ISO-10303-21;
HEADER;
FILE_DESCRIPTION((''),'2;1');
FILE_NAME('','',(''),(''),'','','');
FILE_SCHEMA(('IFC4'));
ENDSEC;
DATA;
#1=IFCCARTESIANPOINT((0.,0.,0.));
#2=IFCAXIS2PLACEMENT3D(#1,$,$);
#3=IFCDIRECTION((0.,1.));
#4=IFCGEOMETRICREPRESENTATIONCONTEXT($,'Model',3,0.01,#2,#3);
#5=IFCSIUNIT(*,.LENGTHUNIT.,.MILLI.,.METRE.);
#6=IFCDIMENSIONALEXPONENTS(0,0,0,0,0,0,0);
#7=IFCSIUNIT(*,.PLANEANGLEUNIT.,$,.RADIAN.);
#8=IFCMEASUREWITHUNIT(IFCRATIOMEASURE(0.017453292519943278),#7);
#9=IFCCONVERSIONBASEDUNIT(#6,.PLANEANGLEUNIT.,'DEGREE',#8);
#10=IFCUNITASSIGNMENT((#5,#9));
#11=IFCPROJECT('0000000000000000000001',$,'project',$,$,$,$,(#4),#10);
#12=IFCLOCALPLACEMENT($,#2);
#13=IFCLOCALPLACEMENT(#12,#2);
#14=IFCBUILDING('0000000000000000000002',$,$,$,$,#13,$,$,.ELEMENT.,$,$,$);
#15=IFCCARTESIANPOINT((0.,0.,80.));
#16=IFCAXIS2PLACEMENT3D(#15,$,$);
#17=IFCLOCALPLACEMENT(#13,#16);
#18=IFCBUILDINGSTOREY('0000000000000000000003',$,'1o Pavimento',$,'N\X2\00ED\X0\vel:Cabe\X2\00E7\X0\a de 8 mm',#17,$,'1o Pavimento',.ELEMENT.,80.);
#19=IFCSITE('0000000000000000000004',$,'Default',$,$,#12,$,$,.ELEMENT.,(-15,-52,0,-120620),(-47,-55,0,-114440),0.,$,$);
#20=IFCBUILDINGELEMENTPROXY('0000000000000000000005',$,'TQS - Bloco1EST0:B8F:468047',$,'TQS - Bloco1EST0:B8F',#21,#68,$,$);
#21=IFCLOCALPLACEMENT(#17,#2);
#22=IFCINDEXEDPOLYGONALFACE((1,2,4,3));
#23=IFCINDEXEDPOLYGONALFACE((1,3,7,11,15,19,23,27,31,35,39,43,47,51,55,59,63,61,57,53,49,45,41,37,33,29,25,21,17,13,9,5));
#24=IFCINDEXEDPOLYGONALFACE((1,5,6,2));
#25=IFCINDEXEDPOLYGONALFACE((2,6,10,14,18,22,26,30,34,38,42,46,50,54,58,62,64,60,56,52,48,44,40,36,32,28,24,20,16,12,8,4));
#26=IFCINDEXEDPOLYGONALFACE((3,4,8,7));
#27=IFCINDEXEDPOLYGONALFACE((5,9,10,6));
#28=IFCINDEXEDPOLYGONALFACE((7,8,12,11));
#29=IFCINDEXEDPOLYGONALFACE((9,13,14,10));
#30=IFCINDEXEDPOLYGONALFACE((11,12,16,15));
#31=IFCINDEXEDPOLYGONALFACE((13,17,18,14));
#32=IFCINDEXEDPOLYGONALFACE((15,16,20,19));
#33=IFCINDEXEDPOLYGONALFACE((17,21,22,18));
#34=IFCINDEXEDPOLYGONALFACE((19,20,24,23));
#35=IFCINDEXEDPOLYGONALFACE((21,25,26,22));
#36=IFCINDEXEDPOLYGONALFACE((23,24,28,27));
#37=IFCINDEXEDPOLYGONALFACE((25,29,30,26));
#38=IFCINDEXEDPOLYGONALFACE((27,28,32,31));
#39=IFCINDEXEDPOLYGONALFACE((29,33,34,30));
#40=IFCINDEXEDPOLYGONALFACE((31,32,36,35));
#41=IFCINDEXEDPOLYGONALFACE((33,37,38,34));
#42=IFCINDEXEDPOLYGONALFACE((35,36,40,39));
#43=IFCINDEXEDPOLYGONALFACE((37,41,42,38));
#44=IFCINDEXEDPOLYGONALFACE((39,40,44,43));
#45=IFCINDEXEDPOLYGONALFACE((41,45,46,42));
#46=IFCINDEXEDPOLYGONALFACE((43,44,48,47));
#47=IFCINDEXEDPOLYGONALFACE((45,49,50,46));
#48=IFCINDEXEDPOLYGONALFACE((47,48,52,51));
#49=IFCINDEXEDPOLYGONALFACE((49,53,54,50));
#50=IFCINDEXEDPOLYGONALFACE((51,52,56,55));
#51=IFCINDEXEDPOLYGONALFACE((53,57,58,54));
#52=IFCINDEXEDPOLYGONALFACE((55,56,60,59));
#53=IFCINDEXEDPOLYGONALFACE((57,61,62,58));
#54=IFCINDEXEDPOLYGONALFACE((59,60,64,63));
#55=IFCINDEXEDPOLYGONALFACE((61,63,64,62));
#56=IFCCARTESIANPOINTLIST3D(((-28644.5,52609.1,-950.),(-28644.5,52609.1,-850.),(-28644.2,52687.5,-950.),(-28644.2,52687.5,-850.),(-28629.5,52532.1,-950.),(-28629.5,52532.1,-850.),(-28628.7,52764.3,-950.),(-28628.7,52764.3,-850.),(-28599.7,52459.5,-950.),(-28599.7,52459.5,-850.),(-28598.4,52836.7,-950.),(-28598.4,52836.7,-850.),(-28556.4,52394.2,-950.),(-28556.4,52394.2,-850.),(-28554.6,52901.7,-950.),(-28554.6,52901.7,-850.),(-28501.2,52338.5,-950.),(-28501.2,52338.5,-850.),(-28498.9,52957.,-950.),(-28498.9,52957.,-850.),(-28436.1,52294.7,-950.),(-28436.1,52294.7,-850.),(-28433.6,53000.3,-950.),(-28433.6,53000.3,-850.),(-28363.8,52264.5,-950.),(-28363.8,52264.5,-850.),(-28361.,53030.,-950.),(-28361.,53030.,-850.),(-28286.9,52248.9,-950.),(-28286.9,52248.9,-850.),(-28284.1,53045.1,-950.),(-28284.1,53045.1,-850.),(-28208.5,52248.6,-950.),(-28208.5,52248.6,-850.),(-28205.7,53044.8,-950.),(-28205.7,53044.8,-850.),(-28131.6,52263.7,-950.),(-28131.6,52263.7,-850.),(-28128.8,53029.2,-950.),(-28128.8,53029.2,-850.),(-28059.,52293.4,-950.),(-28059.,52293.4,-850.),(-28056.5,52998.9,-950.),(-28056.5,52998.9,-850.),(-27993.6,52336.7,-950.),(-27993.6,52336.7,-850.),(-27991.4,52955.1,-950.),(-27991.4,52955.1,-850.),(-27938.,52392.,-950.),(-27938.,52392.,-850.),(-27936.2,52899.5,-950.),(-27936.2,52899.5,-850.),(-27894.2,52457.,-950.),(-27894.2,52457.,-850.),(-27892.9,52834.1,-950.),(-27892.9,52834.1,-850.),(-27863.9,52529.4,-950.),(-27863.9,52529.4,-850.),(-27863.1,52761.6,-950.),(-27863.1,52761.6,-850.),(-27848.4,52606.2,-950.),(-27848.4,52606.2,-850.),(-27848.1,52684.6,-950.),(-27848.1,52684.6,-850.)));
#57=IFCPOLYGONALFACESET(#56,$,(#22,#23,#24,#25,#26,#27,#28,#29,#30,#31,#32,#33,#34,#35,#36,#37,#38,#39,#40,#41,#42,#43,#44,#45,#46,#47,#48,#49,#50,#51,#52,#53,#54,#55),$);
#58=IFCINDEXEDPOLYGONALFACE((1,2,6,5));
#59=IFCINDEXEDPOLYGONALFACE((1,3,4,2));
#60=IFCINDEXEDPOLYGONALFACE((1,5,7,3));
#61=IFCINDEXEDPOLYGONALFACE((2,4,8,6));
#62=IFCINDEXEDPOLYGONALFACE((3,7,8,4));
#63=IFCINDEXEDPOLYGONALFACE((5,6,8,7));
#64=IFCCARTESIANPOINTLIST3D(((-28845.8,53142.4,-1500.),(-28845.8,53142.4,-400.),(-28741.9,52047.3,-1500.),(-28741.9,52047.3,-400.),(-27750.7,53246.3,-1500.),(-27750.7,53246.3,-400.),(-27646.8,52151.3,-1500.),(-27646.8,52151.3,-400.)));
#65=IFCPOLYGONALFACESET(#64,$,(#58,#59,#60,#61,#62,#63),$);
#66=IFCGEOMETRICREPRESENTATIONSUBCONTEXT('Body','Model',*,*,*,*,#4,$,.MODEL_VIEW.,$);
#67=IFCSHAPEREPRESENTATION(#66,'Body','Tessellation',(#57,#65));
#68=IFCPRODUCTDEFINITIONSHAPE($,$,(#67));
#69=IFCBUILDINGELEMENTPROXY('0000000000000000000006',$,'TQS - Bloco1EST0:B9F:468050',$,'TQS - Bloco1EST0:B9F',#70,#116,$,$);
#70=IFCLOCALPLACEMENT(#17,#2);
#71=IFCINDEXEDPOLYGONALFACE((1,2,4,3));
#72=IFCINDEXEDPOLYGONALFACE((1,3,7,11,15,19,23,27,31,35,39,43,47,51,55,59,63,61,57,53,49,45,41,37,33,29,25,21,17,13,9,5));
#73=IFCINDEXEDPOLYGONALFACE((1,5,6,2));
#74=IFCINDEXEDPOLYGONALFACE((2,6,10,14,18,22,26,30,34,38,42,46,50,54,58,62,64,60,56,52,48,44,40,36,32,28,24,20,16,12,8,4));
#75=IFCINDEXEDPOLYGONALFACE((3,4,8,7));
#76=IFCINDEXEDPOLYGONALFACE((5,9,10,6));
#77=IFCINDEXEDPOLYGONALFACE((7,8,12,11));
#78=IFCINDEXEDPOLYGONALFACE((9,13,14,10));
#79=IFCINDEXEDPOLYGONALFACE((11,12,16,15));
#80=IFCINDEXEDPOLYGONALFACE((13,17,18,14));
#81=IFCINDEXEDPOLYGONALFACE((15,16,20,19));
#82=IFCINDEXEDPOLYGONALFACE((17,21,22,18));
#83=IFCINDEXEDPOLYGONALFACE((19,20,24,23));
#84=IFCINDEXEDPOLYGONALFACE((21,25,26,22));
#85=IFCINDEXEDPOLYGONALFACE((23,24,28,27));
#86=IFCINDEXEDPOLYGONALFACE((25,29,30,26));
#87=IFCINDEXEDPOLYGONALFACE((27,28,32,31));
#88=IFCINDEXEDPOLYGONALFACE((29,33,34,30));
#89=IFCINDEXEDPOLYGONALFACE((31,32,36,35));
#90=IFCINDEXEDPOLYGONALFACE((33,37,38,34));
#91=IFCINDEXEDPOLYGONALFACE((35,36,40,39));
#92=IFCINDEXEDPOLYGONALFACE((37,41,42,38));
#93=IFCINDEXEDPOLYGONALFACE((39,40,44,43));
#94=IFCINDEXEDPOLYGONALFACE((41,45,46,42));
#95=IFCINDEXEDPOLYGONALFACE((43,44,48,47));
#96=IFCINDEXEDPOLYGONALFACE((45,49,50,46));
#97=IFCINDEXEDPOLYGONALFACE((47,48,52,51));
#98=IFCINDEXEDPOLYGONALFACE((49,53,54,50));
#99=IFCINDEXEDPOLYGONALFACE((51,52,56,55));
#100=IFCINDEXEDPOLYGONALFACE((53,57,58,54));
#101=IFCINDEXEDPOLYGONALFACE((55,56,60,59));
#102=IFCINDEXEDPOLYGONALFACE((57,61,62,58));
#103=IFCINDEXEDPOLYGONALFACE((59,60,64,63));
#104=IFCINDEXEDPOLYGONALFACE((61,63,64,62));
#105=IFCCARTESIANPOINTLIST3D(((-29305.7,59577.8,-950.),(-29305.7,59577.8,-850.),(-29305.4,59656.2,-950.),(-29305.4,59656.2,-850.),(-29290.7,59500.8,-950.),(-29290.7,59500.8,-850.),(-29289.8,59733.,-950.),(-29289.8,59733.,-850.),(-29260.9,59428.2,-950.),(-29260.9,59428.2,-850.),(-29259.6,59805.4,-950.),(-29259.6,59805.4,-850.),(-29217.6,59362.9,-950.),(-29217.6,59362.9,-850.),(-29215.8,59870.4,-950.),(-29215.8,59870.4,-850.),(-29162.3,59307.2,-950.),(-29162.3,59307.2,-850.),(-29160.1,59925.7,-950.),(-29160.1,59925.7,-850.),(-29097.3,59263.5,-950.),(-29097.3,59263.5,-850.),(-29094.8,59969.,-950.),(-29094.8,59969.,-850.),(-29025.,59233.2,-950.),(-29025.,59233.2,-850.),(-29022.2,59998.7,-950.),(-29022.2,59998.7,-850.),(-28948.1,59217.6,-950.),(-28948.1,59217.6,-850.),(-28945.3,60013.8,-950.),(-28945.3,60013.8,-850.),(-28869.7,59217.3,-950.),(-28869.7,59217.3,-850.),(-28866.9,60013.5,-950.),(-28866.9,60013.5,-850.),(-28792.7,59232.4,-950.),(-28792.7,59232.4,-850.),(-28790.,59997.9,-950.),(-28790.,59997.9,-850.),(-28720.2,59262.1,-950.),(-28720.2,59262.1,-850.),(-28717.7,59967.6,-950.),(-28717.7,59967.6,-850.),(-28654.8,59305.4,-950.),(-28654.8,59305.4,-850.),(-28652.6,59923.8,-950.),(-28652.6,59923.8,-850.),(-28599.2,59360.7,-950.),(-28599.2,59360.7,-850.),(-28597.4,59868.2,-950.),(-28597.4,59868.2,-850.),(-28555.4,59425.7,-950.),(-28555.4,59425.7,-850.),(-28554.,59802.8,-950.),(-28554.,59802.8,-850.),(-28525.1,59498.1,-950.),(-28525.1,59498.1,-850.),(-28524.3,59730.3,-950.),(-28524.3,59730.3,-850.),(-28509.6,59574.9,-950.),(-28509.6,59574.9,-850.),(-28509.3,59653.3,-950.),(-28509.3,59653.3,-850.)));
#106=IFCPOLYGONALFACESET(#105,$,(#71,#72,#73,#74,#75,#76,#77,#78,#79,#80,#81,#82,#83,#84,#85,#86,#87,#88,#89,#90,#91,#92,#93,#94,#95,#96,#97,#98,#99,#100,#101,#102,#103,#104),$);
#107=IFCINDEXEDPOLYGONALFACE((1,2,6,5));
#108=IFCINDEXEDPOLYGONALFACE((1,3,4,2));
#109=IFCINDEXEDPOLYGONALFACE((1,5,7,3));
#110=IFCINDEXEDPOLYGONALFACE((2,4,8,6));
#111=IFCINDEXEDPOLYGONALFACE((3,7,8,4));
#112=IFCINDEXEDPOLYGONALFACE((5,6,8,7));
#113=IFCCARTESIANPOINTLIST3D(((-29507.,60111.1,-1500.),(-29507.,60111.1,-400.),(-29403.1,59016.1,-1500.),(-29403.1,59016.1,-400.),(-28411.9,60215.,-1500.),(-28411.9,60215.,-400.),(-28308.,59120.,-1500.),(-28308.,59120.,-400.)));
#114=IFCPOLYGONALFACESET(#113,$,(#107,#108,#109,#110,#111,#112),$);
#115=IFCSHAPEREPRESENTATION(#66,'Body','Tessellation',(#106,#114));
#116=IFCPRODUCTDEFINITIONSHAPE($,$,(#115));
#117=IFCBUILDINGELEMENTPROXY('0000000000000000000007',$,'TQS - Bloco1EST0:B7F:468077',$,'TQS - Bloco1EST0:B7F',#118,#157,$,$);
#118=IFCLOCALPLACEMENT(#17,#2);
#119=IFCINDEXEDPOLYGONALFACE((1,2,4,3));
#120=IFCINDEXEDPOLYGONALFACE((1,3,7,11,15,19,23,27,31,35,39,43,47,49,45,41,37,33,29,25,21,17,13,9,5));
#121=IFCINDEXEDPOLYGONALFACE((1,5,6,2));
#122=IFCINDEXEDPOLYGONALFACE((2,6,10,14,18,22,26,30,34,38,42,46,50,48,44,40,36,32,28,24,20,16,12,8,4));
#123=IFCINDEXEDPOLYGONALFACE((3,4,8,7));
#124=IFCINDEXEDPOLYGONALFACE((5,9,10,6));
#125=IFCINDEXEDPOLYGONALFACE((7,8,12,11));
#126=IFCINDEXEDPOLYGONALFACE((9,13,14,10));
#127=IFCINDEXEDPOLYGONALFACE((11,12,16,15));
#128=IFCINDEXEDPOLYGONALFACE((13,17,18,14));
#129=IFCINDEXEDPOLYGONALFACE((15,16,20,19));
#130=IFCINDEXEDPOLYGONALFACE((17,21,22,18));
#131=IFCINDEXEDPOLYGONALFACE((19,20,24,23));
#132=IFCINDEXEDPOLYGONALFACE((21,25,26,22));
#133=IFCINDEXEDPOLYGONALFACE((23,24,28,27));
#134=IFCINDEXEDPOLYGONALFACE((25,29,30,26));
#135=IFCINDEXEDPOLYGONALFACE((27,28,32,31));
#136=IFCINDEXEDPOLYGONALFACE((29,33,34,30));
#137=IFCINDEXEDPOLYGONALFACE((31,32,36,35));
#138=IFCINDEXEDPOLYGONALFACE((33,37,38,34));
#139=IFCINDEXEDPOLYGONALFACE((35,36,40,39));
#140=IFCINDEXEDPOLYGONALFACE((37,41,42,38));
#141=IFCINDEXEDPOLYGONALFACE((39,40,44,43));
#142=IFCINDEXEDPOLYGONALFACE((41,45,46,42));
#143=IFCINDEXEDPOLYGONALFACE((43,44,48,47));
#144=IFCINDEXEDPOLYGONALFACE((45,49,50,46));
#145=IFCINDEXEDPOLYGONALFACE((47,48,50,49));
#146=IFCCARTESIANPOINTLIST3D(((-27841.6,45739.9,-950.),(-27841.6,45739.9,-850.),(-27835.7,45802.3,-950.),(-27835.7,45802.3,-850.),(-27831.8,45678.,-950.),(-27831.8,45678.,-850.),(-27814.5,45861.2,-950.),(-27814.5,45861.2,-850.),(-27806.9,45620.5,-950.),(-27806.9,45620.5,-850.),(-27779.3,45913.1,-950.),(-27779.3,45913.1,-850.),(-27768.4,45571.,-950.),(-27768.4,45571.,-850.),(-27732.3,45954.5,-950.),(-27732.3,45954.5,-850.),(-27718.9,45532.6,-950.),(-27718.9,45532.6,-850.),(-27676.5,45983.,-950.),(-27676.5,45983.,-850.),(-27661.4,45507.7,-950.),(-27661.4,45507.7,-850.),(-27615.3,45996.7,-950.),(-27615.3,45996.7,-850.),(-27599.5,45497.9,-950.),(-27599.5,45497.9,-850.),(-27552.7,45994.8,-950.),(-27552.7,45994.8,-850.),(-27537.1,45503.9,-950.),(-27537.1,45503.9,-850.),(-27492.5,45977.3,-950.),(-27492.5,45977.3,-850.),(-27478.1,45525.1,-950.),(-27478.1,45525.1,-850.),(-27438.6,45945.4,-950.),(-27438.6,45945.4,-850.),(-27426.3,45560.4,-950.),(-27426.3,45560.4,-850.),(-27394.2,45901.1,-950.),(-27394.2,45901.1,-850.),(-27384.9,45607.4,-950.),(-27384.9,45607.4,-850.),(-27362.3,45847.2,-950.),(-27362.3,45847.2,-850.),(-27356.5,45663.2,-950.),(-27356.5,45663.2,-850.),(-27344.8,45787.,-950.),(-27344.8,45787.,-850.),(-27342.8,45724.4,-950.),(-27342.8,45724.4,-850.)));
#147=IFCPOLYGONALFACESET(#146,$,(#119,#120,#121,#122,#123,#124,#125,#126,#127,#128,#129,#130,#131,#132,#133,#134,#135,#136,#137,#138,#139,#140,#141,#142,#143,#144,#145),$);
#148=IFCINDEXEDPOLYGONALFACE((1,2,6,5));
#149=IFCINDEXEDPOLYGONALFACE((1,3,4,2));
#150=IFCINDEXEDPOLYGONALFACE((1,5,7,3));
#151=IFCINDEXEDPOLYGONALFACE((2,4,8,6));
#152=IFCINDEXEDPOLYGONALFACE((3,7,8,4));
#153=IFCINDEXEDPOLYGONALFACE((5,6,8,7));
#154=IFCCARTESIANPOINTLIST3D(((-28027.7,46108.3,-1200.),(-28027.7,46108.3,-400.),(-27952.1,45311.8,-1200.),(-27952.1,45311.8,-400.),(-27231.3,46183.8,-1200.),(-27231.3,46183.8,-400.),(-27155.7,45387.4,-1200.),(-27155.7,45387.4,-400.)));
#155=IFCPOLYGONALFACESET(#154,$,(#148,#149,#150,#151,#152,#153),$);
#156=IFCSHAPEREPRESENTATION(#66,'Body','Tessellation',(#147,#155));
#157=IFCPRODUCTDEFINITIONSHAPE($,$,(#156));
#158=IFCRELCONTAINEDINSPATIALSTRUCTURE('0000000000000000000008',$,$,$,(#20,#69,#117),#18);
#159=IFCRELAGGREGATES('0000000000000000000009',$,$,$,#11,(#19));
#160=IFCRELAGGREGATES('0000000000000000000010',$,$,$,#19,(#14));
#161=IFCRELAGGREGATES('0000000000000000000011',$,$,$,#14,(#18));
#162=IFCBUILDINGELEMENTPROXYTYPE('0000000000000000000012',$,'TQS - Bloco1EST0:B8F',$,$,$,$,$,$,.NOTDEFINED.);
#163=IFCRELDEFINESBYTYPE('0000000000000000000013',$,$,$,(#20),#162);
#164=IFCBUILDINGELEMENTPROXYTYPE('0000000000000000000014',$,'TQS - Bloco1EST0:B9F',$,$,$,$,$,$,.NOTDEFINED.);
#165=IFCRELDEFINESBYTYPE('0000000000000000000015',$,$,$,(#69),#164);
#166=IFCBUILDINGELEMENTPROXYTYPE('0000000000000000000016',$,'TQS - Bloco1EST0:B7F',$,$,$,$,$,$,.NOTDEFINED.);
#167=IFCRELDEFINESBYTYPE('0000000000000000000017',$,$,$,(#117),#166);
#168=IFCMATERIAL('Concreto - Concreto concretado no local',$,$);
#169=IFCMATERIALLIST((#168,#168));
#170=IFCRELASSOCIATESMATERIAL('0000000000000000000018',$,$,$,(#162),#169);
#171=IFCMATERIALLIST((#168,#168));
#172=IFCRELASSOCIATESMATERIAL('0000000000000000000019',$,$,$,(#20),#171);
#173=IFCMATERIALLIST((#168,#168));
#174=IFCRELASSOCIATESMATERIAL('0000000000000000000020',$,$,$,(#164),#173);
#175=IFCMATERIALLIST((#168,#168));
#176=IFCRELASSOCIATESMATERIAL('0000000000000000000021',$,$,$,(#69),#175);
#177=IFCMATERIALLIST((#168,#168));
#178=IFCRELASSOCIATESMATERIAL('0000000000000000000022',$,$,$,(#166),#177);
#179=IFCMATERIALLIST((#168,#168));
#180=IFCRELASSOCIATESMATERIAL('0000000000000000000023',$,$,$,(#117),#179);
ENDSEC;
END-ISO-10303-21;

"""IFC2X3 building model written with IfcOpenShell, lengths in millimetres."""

from ifc_helpers import new_model, entity, si_unit, converted_unit, direction, frame, frame_2d, origin, origin_2d_with_axis, place, context, subcontext, project, spatial, rectangle, circle, extrude, source, transform, mapped, material, material_list, type_object, type_shapes, element, save


model = new_model("IFC2X3")

# Units and contexts
model_context = context("Model", 3, precision=0.01, world=origin(), true_north=direction((0.0, 1.0)))
body_context = subcontext(model_context, "Body", "Model", "MODEL_VIEW")
ifc_project = project(units=[si_unit("LENGTHUNIT", "METRE", prefix="MILLI"), converted_unit("PLANEANGLEUNIT", "DEGREE", entity("IfcRatioMeasure", 0.017453292519943278), si_unit("PLANEANGLEUNIT", "RADIAN"), dimensions=[0, 0, 0, 0, 0, 0, 0])], contexts=[model_context])

# Site, building, storey
site_placement = place(None, origin())
site = spatial("IfcSite", under=ifc_project, at=site_placement, Name="Default", CompositionType="ELEMENT", RefLatitude=(-15, -52, 0, -120620), RefLongitude=(-47, -55, 0, -114440), RefElevation=0.0)
building_placement = place(site_placement, origin())
building = spatial("IfcBuilding", under=site, at=building_placement, CompositionType="ELEMENT")
storey_placement = place(building_placement, frame((0.0, 0.0, 80.0)))
storey = spatial("IfcBuildingStorey", under=building, at=storey_placement, Name="1o Pavimento", ObjectType="Nível:Cabeça de 8 mm", LongName="1o Pavimento", CompositionType="ELEMENT", Elevation=80.0)

# Building element proxies
ifc_material_1 = material(Name="Concreto - Concreto concretado no local")
ifc_material_list_1 = material_list([ifc_material_1, ifc_material_1])
ifc_material_list_2 = material_list([ifc_material_1, ifc_material_1])
building_element_proxy_type_1 = type_object("IfcBuildingElementProxyType", Name="TQS - Bloco1EST0:B8F", PredefinedType="NOTDEFINED", material=ifc_material_list_2)
shared_shape_1 = source(origin(), body_context, "Body", "SweptSolid", [
    extrude(circle(Radius=400.0, at=frame_2d((0.0, 0.0), x_axis=(1.0, 0.0))), frame((0.0, 0.0, -550.0)), (0.0, 0.0, 1.0), 100.0),
    extrude(rectangle(XDim=1100.0, YDim=1100.0, at=origin_2d_with_axis()), frame((0.0, 0.0, -1100.0), z_axis=(0.0, 0.0, 1.0), x_axis=(-1.0, 0.0, 0.0)), (0.0, 0.0, 1.0), 1100.0),
])
type_shapes(building_element_proxy_type_1, [shared_shape_1])
proxy_1_placement = place(storey_placement, frame((-28246.3, 52646.8, -400.0), z_axis=(0.0, 0.0, 1.0), x_axis=(-0.094456, 0.995529, 0.0)))
element("IfcBuildingElementProxy", 1, at=proxy_1_placement, inside=storey, type_object=building_element_proxy_type_1, material=ifc_material_list_1, Name="TQS - Bloco1EST0:B8F:468047", ObjectType="TQS - Bloco1EST0:B8F", context=body_context, shape_type="MappedRepresentation", body=[
    mapped(shared_shape_1, transform((0.0, 0.0, 0.0), scale=1.0)),
])
ifc_material_list_3 = material_list([ifc_material_1, ifc_material_1])
ifc_material_list_4 = material_list([ifc_material_1, ifc_material_1])
building_element_proxy_type_2 = type_object("IfcBuildingElementProxyType", Name="TQS - Bloco1EST0:B9F", PredefinedType="NOTDEFINED", material=ifc_material_list_4)
shared_shape_2 = source(origin(), body_context, "Body", "SweptSolid", [
    extrude(circle(Radius=400.0, at=frame_2d((0.0, 0.0), x_axis=(1.0, 0.0))), frame((0.0, 0.0, -550.0)), (0.0, 0.0, 1.0), 100.0),
    extrude(rectangle(XDim=1100.0, YDim=1100.0, at=origin_2d_with_axis()), frame((0.0, 0.0, -1100.0), z_axis=(0.0, 0.0, 1.0), x_axis=(-1.0, 0.0, 0.0)), (0.0, 0.0, 1.0), 1100.0),
])
type_shapes(building_element_proxy_type_2, [shared_shape_2])
proxy_2_placement = place(storey_placement, frame((-28907.5, 59615.5, -400.0), z_axis=(0.0, 0.0, 1.0), x_axis=(-0.094456, 0.995529, 0.0)))
element("IfcBuildingElementProxy", 2, at=proxy_2_placement, inside=storey, type_object=building_element_proxy_type_2, material=ifc_material_list_3, Name="TQS - Bloco1EST0:B9F:468050", ObjectType="TQS - Bloco1EST0:B9F", context=body_context, shape_type="MappedRepresentation", body=[
    mapped(shared_shape_2, transform((0.0, 0.0, 0.0), scale=1.0)),
])
ifc_material_list_5 = material_list([ifc_material_1, ifc_material_1])
ifc_material_list_6 = material_list([ifc_material_1, ifc_material_1])
building_element_proxy_type_3 = type_object("IfcBuildingElementProxyType", Name="TQS - Bloco1EST0:B7F", PredefinedType="NOTDEFINED", material=ifc_material_list_6)
shared_shape_3 = source(origin(), body_context, "Body", "SweptSolid", [
    extrude(circle(Radius=250.0, at=frame_2d((0.0, 0.0), x_axis=(1.0, 0.0))), frame((0.0, 0.0, -550.0)), (0.0, 0.0, 1.0), 100.0),
    extrude(rectangle(XDim=800.0, YDim=800.0, at=origin_2d_with_axis()), frame((0.0, 0.0, -800.0), z_axis=(0.0, 0.0, 1.0), x_axis=(-1.0, 0.0, 0.0)), (0.0, 0.0, 1.0), 800.0),
])
type_shapes(building_element_proxy_type_3, [shared_shape_3])
proxy_3_placement = place(storey_placement, frame((-27591.7, 45747.8, -400.0), z_axis=(0.0, 0.0, 1.0), x_axis=(-0.094456, 0.995529, 0.0)))
element("IfcBuildingElementProxy", 3, at=proxy_3_placement, inside=storey, type_object=building_element_proxy_type_3, material=ifc_material_list_5, Name="TQS - Bloco1EST0:B7F:468077", ObjectType="TQS - Bloco1EST0:B7F", context=body_context, shape_type="MappedRepresentation", body=[
    mapped(shared_shape_3, transform((0.0, 0.0, 0.0), scale=1.0)),
])

save(model, "model.ifc")
